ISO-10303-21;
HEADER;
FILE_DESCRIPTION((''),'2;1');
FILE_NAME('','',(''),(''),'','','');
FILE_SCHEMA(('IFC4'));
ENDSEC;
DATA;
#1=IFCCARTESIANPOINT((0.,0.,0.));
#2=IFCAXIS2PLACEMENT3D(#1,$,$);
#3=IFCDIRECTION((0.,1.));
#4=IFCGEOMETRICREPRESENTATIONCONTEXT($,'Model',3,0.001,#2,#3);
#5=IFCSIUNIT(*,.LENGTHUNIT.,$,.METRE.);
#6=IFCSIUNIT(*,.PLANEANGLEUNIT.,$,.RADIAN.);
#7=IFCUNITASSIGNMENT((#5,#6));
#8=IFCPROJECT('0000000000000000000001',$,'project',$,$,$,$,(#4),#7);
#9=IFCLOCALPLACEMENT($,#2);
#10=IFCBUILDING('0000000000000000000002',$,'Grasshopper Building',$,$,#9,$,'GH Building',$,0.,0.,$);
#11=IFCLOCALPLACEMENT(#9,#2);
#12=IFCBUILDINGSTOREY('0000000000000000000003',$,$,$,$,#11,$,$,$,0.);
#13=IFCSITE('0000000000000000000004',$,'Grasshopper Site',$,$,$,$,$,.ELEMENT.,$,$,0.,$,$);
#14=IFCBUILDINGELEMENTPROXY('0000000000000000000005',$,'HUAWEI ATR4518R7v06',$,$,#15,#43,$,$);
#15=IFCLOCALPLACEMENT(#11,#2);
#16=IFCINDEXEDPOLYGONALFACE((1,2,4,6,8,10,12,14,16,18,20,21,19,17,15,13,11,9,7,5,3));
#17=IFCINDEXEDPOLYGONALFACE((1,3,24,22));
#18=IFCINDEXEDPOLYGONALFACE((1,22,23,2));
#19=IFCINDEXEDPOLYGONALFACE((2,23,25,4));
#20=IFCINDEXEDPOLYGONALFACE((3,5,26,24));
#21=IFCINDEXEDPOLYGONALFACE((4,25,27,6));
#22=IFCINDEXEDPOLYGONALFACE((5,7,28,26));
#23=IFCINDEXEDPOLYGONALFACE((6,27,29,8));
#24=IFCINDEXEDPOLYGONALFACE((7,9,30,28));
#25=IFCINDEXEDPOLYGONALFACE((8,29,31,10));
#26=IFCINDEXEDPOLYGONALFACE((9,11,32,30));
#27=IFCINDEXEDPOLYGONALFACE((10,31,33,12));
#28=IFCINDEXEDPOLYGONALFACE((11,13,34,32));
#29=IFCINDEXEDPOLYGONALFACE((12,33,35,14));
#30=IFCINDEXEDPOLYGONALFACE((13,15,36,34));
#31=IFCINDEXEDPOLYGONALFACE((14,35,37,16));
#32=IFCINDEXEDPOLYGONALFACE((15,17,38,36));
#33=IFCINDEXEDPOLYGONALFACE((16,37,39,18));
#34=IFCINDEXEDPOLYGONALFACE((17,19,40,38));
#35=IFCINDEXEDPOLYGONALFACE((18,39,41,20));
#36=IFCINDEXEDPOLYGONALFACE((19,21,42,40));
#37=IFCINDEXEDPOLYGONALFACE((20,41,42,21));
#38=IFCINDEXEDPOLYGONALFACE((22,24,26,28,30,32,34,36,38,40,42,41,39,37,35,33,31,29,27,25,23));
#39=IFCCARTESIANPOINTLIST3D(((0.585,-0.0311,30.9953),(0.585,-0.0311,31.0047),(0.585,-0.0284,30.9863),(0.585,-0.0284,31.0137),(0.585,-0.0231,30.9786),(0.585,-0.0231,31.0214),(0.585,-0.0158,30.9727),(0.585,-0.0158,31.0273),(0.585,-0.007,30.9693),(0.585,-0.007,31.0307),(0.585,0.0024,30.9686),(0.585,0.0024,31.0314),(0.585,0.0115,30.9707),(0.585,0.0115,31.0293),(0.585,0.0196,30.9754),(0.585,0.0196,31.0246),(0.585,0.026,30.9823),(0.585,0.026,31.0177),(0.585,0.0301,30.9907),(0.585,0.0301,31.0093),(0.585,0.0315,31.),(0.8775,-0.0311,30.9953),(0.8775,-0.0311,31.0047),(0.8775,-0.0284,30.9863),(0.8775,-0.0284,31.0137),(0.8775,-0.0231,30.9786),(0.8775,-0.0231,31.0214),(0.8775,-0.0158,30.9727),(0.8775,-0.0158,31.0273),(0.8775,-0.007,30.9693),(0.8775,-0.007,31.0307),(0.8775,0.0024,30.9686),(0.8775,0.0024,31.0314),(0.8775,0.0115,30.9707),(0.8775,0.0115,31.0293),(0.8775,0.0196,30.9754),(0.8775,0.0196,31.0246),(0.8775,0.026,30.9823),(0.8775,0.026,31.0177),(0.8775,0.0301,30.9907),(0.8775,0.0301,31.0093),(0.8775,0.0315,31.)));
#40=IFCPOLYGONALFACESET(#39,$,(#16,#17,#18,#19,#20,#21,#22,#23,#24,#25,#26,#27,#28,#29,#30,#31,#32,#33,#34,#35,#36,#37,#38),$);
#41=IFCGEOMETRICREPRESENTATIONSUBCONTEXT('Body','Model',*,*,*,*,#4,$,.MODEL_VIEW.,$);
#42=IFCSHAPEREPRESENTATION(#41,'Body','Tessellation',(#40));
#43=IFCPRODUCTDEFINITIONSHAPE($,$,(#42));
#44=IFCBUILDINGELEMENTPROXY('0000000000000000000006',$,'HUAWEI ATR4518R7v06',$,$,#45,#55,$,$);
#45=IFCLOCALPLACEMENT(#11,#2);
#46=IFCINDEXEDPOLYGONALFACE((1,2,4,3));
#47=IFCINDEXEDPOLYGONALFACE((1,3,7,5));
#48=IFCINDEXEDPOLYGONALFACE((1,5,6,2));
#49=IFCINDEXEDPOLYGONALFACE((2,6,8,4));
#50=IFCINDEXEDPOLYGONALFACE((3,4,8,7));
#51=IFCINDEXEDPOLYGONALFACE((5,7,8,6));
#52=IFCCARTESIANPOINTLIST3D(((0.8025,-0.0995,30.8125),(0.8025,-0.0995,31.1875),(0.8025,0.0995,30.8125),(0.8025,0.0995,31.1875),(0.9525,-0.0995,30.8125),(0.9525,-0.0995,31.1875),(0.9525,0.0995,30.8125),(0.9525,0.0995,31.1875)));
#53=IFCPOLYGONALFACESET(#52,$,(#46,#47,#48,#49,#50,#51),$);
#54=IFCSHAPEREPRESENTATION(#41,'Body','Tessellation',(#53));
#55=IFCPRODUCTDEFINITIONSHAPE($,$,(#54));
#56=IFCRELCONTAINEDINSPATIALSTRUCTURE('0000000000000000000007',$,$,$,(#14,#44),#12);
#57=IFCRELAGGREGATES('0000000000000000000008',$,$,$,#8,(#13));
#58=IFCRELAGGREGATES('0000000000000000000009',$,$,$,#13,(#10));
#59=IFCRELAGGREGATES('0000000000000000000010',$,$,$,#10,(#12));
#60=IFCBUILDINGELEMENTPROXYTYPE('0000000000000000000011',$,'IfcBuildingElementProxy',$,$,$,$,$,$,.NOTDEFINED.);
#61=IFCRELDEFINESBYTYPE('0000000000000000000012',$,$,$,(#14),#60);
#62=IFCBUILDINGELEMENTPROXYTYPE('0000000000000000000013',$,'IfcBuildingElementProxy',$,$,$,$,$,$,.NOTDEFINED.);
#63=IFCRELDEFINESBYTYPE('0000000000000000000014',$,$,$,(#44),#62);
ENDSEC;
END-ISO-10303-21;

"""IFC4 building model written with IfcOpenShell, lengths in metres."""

from ifc_helpers import new_model, si_unit, direction, frame, frame_2d, origin, place, context, subcontext, project, spatial, rectangle, circle, extrude, source, transform, mapped, type_object, type_shapes, element, save


model = new_model("IFC4")

# Units and contexts
model_context = context("Model", 3, precision=0.001, world=origin(), true_north=direction((0.0, 1.0)))
body_context = subcontext(model_context, "Body", "Model", "MODEL_VIEW")
ifc_project = project(units=[si_unit("LENGTHUNIT", "METRE"), si_unit("PLANEANGLEUNIT", "RADIAN")], contexts=[model_context])

# Site, building, storey
site = spatial("IfcSite", under=ifc_project, Name="Grasshopper Site", CompositionType="ELEMENT", RefElevation=0.0)
building_placement = place(None, origin())
building = spatial("IfcBuilding", under=site, at=building_placement, Name="Grasshopper Building", LongName="GH Building", ElevationOfRefHeight=0.0, ElevationOfTerrain=0.0)
storey_placement = place(building_placement, origin())
storey = spatial("IfcBuildingStorey", under=building, at=storey_placement, Elevation=0.0)

# Building element proxies
building_element_proxy_type_1 = type_object("IfcBuildingElementProxyType", Name="IfcBuildingElementProxy", PredefinedType="NOTDEFINED")
shared_shape_1 = source(origin(), body_context, "Body", "SweptSolid", [
    extrude(circle(Radius=0.0315), frame((0.585, 0.0, 31.0), z_axis=(1.0, 0.0, 0.0), x_axis=(0.0, 1.0, 0.0)), (0.0, 0.0, 1.0), 0.2925),
])
type_shapes(building_element_proxy_type_1, [shared_shape_1])
for number, where, name in (
    (1, (0.0, 0.0, 0.0), "HUAWEI ATR4518R7v06"),
):
    element("IfcBuildingElementProxy", number, at=place(storey_placement, frame(where)), inside=storey, type_object=building_element_proxy_type_1, Name=name, context=body_context, shape_type="MappedRepresentation", body=[
        mapped(shared_shape_1, transform((0.0, 0.0, 0.0), scale=1.0)),
    ])
building_element_proxy_type_2 = type_object("IfcBuildingElementProxyType", Name="IfcBuildingElementProxy", PredefinedType="NOTDEFINED")
shared_shape_2 = source(origin(), body_context, "Body", "SweptSolid", [
    extrude(rectangle(XDim=0.375, YDim=0.199, at=frame_2d((0.0, 0.0), x_axis=(0.0, 1.0))), frame((0.9525, 0.0, 31.0), z_axis=(-1.0, 0.0, 0.0), x_axis=(0.0, 1.0, 0.0)), (0.0, 0.0, 1.0), 0.15),
])
type_shapes(building_element_proxy_type_2, [shared_shape_2])
for number, where, name in (
    (2, (0.0, 0.0, 0.0), "HUAWEI ATR4518R7v06"),
):
    element("IfcBuildingElementProxy", number, at=place(storey_placement, frame(where)), inside=storey, type_object=building_element_proxy_type_2, Name=name, context=body_context, shape_type="MappedRepresentation", body=[
        mapped(shared_shape_2, transform((0.0, 0.0, 0.0), scale=1.0)),
    ])

save(model, "model.ifc")
